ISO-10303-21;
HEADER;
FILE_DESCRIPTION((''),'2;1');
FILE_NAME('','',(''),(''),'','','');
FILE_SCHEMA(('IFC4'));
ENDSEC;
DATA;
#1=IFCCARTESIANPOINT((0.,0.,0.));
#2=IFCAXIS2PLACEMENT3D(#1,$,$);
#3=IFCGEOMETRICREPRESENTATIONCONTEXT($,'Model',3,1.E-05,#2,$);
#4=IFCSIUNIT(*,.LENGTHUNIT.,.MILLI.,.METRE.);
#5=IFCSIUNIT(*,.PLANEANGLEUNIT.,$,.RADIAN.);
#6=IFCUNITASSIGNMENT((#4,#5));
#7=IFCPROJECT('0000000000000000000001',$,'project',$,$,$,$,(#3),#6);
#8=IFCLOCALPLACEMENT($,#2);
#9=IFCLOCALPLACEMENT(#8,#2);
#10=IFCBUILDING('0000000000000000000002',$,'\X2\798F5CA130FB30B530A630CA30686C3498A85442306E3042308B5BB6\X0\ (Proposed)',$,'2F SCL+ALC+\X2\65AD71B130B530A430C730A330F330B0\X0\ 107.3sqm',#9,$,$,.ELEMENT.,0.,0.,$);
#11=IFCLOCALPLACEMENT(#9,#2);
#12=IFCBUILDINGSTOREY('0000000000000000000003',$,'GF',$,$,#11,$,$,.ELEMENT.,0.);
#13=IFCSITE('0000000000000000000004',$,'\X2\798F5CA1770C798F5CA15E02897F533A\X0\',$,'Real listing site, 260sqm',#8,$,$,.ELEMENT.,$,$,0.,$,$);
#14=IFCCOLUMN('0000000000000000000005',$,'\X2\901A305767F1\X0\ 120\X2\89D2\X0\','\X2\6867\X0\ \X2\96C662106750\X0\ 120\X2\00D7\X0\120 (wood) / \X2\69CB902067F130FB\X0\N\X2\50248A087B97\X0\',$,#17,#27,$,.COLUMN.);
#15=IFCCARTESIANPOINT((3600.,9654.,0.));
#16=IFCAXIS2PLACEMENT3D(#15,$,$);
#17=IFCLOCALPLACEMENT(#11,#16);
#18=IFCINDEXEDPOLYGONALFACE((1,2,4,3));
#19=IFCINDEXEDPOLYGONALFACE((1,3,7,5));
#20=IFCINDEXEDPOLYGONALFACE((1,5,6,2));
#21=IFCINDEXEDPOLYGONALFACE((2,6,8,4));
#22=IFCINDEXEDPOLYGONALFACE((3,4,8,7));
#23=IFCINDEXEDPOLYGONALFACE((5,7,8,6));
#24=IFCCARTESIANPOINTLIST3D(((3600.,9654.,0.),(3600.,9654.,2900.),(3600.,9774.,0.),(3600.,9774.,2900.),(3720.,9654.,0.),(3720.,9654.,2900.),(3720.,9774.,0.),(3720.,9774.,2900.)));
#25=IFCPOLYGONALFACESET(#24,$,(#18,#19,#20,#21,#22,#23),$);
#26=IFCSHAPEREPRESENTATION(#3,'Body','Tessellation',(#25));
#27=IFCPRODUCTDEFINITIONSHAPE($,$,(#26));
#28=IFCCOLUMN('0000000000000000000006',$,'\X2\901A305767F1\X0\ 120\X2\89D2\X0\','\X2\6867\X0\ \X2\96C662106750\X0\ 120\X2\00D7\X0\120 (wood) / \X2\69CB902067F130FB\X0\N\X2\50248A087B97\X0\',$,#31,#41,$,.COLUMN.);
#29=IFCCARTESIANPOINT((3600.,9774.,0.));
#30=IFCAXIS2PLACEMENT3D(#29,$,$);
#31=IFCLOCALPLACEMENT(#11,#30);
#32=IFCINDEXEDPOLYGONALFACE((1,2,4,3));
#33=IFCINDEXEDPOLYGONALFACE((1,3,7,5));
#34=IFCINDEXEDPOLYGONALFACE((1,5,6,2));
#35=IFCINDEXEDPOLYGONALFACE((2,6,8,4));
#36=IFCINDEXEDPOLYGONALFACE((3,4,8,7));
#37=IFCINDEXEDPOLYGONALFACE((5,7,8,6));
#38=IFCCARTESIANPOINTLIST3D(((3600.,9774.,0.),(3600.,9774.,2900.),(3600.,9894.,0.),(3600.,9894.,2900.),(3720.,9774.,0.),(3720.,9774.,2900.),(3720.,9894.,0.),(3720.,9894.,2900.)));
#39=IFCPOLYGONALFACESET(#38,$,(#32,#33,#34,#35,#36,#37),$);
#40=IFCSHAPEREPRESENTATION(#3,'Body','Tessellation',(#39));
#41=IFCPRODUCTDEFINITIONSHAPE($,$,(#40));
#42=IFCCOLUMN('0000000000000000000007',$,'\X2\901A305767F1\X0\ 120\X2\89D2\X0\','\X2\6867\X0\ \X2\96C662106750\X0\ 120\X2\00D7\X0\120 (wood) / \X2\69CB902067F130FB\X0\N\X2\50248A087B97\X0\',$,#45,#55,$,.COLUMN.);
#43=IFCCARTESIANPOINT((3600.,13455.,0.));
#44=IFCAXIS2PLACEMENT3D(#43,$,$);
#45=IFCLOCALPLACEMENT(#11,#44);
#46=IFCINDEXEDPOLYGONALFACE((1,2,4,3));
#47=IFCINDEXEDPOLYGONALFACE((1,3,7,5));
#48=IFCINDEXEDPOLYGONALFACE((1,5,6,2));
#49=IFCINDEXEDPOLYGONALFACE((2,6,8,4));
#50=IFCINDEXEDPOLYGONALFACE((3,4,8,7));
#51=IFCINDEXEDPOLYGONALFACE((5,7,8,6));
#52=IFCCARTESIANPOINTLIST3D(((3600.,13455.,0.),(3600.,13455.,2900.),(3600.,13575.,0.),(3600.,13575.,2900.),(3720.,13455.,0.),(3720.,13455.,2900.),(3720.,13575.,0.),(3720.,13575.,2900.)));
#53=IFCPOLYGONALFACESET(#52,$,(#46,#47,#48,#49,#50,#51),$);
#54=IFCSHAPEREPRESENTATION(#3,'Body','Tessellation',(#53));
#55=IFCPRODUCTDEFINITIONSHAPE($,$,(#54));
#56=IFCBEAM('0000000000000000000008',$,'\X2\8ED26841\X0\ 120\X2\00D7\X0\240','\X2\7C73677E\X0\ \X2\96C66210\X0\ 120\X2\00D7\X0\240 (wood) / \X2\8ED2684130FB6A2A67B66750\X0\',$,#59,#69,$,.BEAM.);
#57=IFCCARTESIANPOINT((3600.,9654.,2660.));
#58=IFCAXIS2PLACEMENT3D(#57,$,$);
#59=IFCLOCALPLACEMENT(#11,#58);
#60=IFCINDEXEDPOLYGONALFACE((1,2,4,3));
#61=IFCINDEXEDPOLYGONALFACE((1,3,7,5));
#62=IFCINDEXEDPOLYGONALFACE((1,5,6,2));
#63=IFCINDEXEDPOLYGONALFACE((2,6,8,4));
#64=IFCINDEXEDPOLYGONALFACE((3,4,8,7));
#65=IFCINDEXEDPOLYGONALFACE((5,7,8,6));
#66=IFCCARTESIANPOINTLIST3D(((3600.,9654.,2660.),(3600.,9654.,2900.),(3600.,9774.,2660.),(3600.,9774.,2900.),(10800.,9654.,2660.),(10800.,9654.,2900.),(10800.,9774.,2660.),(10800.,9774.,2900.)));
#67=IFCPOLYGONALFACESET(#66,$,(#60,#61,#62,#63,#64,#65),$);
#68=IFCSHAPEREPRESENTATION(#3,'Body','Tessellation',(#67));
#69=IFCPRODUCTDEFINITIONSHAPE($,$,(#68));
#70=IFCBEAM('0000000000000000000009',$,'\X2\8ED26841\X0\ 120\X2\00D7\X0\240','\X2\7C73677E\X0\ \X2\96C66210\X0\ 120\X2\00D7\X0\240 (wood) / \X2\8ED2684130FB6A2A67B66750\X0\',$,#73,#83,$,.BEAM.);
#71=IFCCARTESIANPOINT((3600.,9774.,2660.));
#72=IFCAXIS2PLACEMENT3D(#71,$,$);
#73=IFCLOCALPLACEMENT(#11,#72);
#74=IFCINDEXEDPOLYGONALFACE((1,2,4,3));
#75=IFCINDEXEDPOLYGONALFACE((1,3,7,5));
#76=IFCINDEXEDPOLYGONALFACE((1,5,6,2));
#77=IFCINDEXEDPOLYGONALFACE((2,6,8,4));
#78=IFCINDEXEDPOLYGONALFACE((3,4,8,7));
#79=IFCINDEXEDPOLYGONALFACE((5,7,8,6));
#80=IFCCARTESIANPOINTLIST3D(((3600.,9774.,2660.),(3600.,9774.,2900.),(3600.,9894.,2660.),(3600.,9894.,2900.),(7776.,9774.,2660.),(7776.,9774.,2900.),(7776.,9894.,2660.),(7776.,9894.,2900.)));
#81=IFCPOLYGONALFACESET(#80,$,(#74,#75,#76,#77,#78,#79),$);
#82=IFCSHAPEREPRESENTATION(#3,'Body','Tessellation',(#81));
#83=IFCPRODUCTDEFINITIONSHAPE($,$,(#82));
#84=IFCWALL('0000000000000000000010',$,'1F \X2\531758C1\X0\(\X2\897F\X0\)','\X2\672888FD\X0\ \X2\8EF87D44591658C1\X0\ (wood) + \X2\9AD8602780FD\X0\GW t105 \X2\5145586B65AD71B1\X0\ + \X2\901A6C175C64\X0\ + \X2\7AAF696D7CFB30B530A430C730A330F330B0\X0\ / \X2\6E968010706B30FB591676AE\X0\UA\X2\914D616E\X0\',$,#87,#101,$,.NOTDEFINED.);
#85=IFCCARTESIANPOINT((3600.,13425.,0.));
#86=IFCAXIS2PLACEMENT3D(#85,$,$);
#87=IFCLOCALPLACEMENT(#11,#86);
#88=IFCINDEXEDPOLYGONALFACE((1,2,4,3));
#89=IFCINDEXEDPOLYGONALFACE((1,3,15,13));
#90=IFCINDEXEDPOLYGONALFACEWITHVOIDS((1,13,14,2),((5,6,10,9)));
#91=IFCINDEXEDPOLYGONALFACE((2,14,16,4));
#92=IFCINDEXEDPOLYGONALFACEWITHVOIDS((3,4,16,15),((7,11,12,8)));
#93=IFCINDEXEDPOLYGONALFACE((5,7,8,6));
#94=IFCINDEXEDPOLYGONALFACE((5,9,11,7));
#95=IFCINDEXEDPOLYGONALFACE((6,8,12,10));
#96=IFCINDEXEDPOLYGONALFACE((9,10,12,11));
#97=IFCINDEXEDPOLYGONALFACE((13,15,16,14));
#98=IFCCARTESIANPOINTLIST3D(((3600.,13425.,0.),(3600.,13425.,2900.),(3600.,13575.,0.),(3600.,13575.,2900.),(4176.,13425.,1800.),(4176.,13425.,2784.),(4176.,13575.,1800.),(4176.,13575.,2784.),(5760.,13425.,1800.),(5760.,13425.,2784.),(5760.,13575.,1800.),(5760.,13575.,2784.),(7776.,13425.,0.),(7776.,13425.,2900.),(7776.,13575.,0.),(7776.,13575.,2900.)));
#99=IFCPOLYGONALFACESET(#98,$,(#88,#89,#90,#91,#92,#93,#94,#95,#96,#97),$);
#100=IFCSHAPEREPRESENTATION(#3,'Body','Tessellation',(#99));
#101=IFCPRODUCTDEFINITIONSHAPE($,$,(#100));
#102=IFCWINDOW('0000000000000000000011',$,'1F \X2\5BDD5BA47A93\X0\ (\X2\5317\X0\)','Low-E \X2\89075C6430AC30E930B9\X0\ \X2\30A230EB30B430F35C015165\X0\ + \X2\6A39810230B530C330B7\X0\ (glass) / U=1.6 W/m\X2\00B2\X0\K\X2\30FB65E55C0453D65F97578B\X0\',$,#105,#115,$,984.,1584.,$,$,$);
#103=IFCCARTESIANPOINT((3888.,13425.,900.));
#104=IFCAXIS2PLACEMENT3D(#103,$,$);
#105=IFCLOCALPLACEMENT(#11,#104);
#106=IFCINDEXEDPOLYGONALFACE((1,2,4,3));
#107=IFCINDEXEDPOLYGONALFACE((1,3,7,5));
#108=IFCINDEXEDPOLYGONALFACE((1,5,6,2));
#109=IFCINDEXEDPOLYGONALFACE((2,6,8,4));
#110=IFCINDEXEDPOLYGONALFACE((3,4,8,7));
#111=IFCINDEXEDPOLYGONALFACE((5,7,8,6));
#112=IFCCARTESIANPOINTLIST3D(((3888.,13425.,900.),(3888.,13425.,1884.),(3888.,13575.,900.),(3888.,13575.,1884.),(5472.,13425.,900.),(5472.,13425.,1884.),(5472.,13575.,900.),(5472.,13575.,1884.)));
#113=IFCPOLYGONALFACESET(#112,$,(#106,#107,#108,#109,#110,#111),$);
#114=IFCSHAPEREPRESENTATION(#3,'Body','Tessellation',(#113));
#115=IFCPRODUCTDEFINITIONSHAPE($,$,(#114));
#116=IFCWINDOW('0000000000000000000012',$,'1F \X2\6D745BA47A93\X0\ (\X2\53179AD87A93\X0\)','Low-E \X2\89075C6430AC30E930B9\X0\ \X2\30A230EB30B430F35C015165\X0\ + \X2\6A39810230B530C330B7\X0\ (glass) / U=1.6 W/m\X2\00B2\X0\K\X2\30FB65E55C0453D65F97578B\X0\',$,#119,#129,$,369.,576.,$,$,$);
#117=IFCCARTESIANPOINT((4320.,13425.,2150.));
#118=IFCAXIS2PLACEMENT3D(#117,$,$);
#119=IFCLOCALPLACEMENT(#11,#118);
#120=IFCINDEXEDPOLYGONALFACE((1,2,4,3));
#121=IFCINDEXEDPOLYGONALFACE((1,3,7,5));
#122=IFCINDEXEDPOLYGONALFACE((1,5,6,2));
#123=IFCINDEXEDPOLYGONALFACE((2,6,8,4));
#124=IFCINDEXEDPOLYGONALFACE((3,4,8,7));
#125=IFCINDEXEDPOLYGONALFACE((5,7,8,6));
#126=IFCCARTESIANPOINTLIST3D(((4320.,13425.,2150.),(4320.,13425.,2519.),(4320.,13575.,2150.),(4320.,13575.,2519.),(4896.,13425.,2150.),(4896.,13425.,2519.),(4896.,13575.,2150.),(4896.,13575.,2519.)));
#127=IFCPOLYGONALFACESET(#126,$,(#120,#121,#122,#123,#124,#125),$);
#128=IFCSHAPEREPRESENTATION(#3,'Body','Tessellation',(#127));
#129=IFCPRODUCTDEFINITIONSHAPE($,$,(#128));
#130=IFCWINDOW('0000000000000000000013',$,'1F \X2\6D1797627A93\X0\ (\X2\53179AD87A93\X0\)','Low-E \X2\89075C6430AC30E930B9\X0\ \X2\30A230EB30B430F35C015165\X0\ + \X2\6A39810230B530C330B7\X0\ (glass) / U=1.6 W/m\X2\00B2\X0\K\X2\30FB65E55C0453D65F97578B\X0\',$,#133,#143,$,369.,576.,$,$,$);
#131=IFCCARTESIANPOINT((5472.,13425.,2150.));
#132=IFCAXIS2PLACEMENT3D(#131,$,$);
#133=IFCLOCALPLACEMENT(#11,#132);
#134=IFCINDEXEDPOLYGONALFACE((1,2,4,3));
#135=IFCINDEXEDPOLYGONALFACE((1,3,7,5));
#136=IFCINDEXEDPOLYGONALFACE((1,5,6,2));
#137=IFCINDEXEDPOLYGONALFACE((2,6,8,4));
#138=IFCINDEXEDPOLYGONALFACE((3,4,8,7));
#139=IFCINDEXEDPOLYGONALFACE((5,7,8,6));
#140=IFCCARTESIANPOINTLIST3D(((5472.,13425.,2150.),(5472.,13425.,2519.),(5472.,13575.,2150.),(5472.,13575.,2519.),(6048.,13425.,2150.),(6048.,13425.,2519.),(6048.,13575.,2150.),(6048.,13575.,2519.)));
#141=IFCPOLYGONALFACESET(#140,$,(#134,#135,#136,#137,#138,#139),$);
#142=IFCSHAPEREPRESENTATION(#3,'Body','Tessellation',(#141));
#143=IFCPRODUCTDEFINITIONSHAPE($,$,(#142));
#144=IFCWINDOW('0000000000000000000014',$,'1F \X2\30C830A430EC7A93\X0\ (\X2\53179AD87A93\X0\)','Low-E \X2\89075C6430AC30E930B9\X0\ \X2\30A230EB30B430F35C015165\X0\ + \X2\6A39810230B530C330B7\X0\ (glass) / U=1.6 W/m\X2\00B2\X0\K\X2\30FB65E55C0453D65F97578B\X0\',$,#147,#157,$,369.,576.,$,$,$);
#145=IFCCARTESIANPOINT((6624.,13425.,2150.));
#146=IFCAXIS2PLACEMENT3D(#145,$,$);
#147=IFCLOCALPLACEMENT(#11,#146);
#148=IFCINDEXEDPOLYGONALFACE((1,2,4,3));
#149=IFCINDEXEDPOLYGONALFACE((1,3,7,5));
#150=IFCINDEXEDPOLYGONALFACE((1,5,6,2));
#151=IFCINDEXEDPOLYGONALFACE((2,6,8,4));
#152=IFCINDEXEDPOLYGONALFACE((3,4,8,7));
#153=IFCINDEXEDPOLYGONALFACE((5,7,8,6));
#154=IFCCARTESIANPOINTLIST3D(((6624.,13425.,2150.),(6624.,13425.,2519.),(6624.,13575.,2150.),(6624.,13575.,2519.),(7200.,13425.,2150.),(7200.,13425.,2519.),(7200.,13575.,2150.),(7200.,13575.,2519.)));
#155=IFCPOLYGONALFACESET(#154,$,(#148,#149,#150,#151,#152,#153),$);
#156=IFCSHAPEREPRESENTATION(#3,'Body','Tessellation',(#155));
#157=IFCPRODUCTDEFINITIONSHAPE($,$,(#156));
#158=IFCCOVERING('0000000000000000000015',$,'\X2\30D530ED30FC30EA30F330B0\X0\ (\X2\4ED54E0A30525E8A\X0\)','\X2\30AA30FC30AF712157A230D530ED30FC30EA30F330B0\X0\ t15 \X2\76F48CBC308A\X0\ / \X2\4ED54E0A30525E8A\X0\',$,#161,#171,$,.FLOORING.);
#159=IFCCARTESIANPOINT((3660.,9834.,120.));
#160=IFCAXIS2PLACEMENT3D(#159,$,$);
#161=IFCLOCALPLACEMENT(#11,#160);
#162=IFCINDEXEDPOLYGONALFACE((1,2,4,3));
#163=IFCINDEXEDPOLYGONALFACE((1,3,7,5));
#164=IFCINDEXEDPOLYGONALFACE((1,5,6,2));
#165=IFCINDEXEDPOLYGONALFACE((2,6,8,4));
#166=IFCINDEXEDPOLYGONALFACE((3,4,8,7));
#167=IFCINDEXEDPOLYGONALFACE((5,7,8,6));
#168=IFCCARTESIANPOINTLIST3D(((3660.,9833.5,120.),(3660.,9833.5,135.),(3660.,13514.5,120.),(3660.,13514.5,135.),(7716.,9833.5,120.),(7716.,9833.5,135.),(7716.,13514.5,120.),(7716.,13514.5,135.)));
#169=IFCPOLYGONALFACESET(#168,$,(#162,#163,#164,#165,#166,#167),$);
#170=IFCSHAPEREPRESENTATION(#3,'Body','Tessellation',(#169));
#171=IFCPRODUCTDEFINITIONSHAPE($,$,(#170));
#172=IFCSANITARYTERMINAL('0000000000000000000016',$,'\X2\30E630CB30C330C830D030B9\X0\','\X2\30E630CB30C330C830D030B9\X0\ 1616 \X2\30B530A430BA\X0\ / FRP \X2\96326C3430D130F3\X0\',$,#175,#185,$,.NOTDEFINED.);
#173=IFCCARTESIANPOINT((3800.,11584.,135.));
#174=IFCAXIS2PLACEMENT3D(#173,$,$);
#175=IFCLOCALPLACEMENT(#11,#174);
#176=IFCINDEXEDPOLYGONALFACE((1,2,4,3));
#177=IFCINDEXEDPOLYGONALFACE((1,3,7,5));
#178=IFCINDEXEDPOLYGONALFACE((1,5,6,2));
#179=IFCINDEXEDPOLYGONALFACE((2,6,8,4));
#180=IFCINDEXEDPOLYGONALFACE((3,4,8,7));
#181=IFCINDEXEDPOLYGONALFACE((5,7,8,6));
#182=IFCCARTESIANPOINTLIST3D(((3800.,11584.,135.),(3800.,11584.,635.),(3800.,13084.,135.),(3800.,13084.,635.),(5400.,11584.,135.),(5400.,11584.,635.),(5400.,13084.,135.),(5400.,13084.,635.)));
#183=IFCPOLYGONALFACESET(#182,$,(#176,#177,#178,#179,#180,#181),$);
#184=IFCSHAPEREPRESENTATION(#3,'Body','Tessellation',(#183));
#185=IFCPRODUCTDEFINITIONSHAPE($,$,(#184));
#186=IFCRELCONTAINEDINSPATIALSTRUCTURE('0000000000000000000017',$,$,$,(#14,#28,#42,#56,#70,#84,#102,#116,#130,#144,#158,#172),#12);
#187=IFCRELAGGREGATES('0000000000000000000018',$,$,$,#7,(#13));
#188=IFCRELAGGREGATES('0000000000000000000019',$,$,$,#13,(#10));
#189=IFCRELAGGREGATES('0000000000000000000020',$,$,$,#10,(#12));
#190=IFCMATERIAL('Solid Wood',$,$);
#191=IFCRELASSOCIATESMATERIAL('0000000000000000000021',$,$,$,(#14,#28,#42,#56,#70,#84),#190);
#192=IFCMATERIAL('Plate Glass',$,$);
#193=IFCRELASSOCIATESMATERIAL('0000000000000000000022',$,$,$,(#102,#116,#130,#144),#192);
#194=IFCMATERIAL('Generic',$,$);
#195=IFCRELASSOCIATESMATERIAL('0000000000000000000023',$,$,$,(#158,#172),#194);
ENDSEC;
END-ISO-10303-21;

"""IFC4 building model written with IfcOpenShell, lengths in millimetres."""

from ifc_helpers import new_model, si_unit, frame, frame_2d, origin, place, context, project, spatial, rectangle, extrude, material, element, fill, save


model = new_model("IFC4")

# Units and contexts
model_context = context("Model", 3, precision=1e-05, world=origin())
ifc_project = project(units=[si_unit("LENGTHUNIT", "METRE", prefix="MILLI"), si_unit("PLANEANGLEUNIT", "RADIAN")], contexts=[model_context])

# Site, building, storey
site_placement = place(None, origin())
site = spatial("IfcSite", under=ifc_project, at=site_placement, Name="福岡県福岡市西区", ObjectType="Real listing site, 260sqm", CompositionType="ELEMENT", RefElevation=0.0)
building_placement = place(site_placement, origin())
building = spatial("IfcBuilding", under=site, at=building_placement, Name="福岡・サウナと水風呂のある家 (Proposed)", ObjectType="2F SCL+ALC+断熱サイディング 107.3sqm", CompositionType="ELEMENT", ElevationOfRefHeight=0.0, ElevationOfTerrain=0.0)
storey_placement = place(building_placement, origin())
storey = spatial("IfcBuildingStorey", under=building, at=storey_placement, Name="GF", CompositionType="ELEMENT", Elevation=0.0)

# Columns
ifc_material_1 = material(Name="Solid Wood")
column_1_placement = place(storey_placement, frame((3600.0, 9654.0, 0.0)))
element("IfcColumn", 1, at=column_1_placement, inside=storey, material=ifc_material_1, Name="通し柱 120角", Description="桧 集成材 120×120 (wood) / 構造柱・N値計算", PredefinedType="COLUMN", context=model_context, shape_type="SweptSolid", body=[
    extrude(rectangle(XDim=120.0, YDim=120.0, at=frame_2d((60.0, 60.0))), frame((3600.0, 9654.0, 0.0)), (0.0, 0.0, 1.0), 2900.0),
])
column_2_placement = place(storey_placement, frame((3600.0, 9774.0, 0.0)))
element("IfcColumn", 2, at=column_2_placement, inside=storey, material=ifc_material_1, Name="通し柱 120角", Description="桧 集成材 120×120 (wood) / 構造柱・N値計算", PredefinedType="COLUMN", context=model_context, shape_type="SweptSolid", body=[
    extrude(rectangle(XDim=120.0, YDim=120.0, at=frame_2d((60.0, 60.0))), frame((3600.0, 9774.0, 0.0)), (0.0, 0.0, 1.0), 2900.0),
])
column_3_placement = place(storey_placement, frame((3600.0, 13455.0, 0.0)))
element("IfcColumn", 3, at=column_3_placement, inside=storey, material=ifc_material_1, Name="通し柱 120角", Description="桧 集成材 120×120 (wood) / 構造柱・N値計算", PredefinedType="COLUMN", context=model_context, shape_type="SweptSolid", body=[
    extrude(rectangle(XDim=120.0, YDim=120.0, at=frame_2d((60.0, 60.0))), frame((3600.0, 13455.0, 0.0)), (0.0, 0.0, 1.0), 2900.0),
])

# Beams
beam_1_placement = place(storey_placement, frame((3600.0, 9654.0, 2660.0)))
element("IfcBeam", 4, at=beam_1_placement, inside=storey, material=ifc_material_1, Name="軒桁 120×240", Description="米松 集成 120×240 (wood) / 軒桁・横架材", PredefinedType="BEAM", context=model_context, shape_type="SweptSolid", body=[
    extrude(rectangle(XDim=7200.0, YDim=120.0, at=frame_2d((3600.0, 60.0))), frame((3600.0, 9654.0, 2660.0)), (0.0, 0.0, 1.0), 240.0),
])
beam_2_placement = place(storey_placement, frame((3600.0, 9774.0, 2660.0)))
element("IfcBeam", 5, at=beam_2_placement, inside=storey, material=ifc_material_1, Name="軒桁 120×240", Description="米松 集成 120×240 (wood) / 軒桁・横架材", PredefinedType="BEAM", context=model_context, shape_type="SweptSolid", body=[
    extrude(rectangle(XDim=4176.0, YDim=120.0, at=frame_2d((2088.0, 60.0))), frame((3600.0, 9774.0, 2660.0)), (0.0, 0.0, 1.0), 240.0),
])

# Wall, openings, windows
wall_1_placement = place(storey_placement, frame((3600.0, 13425.0, 0.0)))
wall_1 = element("IfcWall", 6, at=wall_1_placement, inside=storey, material=ifc_material_1, Name="1F 北壁(西)", Description="木製 軸組外壁 (wood) + 高性能GW t105 充填断熱 + 通気層 + 窯業系サイディング / 準耐火・外皮UA配慮", PredefinedType="NOTDEFINED", context=model_context, shape_type="SweptSolid", body=[
    extrude(rectangle(XDim=4176.0, YDim=150.0, at=frame_2d((2088.0, 75.0))), frame((3600.0, 13425.0, 0.0)), (0.0, 0.0, 1.0), 2900.0),
])
opening_1_placement = place(storey_placement, frame((3888.0, 13425.0, 900.0)))
opening_1 = element("IfcOpeningElement", 7, at=opening_1_placement, cuts=wall_1, PredefinedType="NOTDEFINED", context=model_context, shape_type="SweptSolid", body=[
    extrude(rectangle(XDim=1584.0, YDim=150.0, at=frame_2d((792.0, 75.0))), frame((3888.0, 13425.0, 900.0)), (0.0, 0.0, 1.0), 984.0),
])
opening_2_placement = place(storey_placement, frame((4320.0, 13425.0, 2150.0)))
opening_2 = element("IfcOpeningElement", 8, at=opening_2_placement, cuts=wall_1, PredefinedType="NOTDEFINED", context=model_context, shape_type="SweptSolid", body=[
    extrude(rectangle(XDim=576.0, YDim=150.0, at=frame_2d((288.0, 75.0))), frame((4320.0, 13425.0, 2150.0)), (0.0, 0.0, 1.0), 369.0),
])
opening_3_placement = place(storey_placement, frame((5472.0, 13425.0, 2150.0)))
opening_3 = element("IfcOpeningElement", 9, at=opening_3_placement, cuts=wall_1, PredefinedType="NOTDEFINED", context=model_context, shape_type="SweptSolid", body=[
    extrude(rectangle(XDim=576.0, YDim=150.0, at=frame_2d((288.0, 75.0))), frame((5472.0, 13425.0, 2150.0)), (0.0, 0.0, 1.0), 369.0),
])
opening_4_placement = place(storey_placement, frame((6624.0, 13425.0, 2150.0)))
opening_4 = element("IfcOpeningElement", 10, at=opening_4_placement, cuts=wall_1, PredefinedType="NOTDEFINED", context=model_context, shape_type="SweptSolid", body=[
    extrude(rectangle(XDim=576.0, YDim=150.0, at=frame_2d((288.0, 75.0))), frame((6624.0, 13425.0, 2150.0)), (0.0, 0.0, 1.0), 369.0),
])
ifc_material_2 = material(Name="Plate Glass")
window_1_placement = place(storey_placement, frame((3888.0, 13425.0, 900.0)))
window_1 = element("IfcWindow", 11, at=window_1_placement, inside=storey, material=ifc_material_2, Name="1F 寝室窓 (北)", Description="Low-E 複層ガラス アルゴン封入 + 樹脂サッシ (glass) / U=1.6 W/m²K・日射取得型", OverallHeight=984.0, OverallWidth=1584.0, context=model_context, shape_type="SweptSolid", body=[
    extrude(rectangle(XDim=1584.0, YDim=150.0, at=frame_2d((792.0, 75.0))), frame((3888.0, 13425.0, 900.0)), (0.0, 0.0, 1.0), 984.0),
])
fill(opening_1, window_1)
window_2_placement = place(storey_placement, frame((4320.0, 13425.0, 2150.0)))
window_2 = element("IfcWindow", 12, at=window_2_placement, inside=storey, material=ifc_material_2, Name="1F 浴室窓 (北高窓)", Description="Low-E 複層ガラス アルゴン封入 + 樹脂サッシ (glass) / U=1.6 W/m²K・日射取得型", OverallHeight=369.0, OverallWidth=576.0, context=model_context, shape_type="SweptSolid", body=[
    extrude(rectangle(XDim=576.0, YDim=150.0, at=frame_2d((288.0, 75.0))), frame((4320.0, 13425.0, 2150.0)), (0.0, 0.0, 1.0), 369.0),
])
fill(opening_2, window_2)
window_3_placement = place(storey_placement, frame((5472.0, 13425.0, 2150.0)))
window_3 = element("IfcWindow", 13, at=window_3_placement, inside=storey, material=ifc_material_2, Name="1F 洗面窓 (北高窓)", Description="Low-E 複層ガラス アルゴン封入 + 樹脂サッシ (glass) / U=1.6 W/m²K・日射取得型", OverallHeight=369.0, OverallWidth=576.0, context=model_context, shape_type="SweptSolid", body=[
    extrude(rectangle(XDim=576.0, YDim=150.0, at=frame_2d((288.0, 75.0))), frame((5472.0, 13425.0, 2150.0)), (0.0, 0.0, 1.0), 369.0),
])
fill(opening_3, window_3)
window_4_placement = place(storey_placement, frame((6624.0, 13425.0, 2150.0)))
window_4 = element("IfcWindow", 14, at=window_4_placement, inside=storey, material=ifc_material_2, Name="1F トイレ窓 (北高窓)", Description="Low-E 複層ガラス アルゴン封入 + 樹脂サッシ (glass) / U=1.6 W/m²K・日射取得型", OverallHeight=369.0, OverallWidth=576.0, context=model_context, shape_type="SweptSolid", body=[
    extrude(rectangle(XDim=576.0, YDim=150.0, at=frame_2d((288.0, 75.0))), frame((6624.0, 13425.0, 2150.0)), (0.0, 0.0, 1.0), 369.0),
])
fill(opening_4, window_4)

# Covering
ifc_material_3 = material(Name="Generic")
covering_placement = place(storey_placement, frame((3660.0, 9834.0, 120.0)))
element("IfcCovering", 15, at=covering_placement, inside=storey, material=ifc_material_3, Name="フローリング (仕上げ床)", Description="オーク無垢フローリング t15 直貼り / 仕上げ床", PredefinedType="FLOORING", context=model_context, shape_type="SweptSolid", body=[
    extrude(rectangle(XDim=4056.0, YDim=3681.0, at=frame_2d((2028.0, 1840.0))), frame((3660.0, 9834.0, 120.0)), (0.0, 0.0, 1.0), 15.0),
])

# Sanitary terminal
sanitary_terminal_placement = place(storey_placement, frame((3800.0, 11584.0, 135.0)))
element("IfcSanitaryTerminal", 16, at=sanitary_terminal_placement, inside=storey, material=ifc_material_3, Name="ユニットバス", Description="ユニットバス 1616 サイズ / FRP 防水パン", PredefinedType="NOTDEFINED", context=model_context, shape_type="SweptSolid", body=[
    extrude(rectangle(XDim=1600.0, YDim=1500.0, at=frame_2d((800.0, 750.0))), frame((3800.0, 11584.0, 135.0)), (0.0, 0.0, 1.0), 500.0),
])

save(model, "model.ifc")
